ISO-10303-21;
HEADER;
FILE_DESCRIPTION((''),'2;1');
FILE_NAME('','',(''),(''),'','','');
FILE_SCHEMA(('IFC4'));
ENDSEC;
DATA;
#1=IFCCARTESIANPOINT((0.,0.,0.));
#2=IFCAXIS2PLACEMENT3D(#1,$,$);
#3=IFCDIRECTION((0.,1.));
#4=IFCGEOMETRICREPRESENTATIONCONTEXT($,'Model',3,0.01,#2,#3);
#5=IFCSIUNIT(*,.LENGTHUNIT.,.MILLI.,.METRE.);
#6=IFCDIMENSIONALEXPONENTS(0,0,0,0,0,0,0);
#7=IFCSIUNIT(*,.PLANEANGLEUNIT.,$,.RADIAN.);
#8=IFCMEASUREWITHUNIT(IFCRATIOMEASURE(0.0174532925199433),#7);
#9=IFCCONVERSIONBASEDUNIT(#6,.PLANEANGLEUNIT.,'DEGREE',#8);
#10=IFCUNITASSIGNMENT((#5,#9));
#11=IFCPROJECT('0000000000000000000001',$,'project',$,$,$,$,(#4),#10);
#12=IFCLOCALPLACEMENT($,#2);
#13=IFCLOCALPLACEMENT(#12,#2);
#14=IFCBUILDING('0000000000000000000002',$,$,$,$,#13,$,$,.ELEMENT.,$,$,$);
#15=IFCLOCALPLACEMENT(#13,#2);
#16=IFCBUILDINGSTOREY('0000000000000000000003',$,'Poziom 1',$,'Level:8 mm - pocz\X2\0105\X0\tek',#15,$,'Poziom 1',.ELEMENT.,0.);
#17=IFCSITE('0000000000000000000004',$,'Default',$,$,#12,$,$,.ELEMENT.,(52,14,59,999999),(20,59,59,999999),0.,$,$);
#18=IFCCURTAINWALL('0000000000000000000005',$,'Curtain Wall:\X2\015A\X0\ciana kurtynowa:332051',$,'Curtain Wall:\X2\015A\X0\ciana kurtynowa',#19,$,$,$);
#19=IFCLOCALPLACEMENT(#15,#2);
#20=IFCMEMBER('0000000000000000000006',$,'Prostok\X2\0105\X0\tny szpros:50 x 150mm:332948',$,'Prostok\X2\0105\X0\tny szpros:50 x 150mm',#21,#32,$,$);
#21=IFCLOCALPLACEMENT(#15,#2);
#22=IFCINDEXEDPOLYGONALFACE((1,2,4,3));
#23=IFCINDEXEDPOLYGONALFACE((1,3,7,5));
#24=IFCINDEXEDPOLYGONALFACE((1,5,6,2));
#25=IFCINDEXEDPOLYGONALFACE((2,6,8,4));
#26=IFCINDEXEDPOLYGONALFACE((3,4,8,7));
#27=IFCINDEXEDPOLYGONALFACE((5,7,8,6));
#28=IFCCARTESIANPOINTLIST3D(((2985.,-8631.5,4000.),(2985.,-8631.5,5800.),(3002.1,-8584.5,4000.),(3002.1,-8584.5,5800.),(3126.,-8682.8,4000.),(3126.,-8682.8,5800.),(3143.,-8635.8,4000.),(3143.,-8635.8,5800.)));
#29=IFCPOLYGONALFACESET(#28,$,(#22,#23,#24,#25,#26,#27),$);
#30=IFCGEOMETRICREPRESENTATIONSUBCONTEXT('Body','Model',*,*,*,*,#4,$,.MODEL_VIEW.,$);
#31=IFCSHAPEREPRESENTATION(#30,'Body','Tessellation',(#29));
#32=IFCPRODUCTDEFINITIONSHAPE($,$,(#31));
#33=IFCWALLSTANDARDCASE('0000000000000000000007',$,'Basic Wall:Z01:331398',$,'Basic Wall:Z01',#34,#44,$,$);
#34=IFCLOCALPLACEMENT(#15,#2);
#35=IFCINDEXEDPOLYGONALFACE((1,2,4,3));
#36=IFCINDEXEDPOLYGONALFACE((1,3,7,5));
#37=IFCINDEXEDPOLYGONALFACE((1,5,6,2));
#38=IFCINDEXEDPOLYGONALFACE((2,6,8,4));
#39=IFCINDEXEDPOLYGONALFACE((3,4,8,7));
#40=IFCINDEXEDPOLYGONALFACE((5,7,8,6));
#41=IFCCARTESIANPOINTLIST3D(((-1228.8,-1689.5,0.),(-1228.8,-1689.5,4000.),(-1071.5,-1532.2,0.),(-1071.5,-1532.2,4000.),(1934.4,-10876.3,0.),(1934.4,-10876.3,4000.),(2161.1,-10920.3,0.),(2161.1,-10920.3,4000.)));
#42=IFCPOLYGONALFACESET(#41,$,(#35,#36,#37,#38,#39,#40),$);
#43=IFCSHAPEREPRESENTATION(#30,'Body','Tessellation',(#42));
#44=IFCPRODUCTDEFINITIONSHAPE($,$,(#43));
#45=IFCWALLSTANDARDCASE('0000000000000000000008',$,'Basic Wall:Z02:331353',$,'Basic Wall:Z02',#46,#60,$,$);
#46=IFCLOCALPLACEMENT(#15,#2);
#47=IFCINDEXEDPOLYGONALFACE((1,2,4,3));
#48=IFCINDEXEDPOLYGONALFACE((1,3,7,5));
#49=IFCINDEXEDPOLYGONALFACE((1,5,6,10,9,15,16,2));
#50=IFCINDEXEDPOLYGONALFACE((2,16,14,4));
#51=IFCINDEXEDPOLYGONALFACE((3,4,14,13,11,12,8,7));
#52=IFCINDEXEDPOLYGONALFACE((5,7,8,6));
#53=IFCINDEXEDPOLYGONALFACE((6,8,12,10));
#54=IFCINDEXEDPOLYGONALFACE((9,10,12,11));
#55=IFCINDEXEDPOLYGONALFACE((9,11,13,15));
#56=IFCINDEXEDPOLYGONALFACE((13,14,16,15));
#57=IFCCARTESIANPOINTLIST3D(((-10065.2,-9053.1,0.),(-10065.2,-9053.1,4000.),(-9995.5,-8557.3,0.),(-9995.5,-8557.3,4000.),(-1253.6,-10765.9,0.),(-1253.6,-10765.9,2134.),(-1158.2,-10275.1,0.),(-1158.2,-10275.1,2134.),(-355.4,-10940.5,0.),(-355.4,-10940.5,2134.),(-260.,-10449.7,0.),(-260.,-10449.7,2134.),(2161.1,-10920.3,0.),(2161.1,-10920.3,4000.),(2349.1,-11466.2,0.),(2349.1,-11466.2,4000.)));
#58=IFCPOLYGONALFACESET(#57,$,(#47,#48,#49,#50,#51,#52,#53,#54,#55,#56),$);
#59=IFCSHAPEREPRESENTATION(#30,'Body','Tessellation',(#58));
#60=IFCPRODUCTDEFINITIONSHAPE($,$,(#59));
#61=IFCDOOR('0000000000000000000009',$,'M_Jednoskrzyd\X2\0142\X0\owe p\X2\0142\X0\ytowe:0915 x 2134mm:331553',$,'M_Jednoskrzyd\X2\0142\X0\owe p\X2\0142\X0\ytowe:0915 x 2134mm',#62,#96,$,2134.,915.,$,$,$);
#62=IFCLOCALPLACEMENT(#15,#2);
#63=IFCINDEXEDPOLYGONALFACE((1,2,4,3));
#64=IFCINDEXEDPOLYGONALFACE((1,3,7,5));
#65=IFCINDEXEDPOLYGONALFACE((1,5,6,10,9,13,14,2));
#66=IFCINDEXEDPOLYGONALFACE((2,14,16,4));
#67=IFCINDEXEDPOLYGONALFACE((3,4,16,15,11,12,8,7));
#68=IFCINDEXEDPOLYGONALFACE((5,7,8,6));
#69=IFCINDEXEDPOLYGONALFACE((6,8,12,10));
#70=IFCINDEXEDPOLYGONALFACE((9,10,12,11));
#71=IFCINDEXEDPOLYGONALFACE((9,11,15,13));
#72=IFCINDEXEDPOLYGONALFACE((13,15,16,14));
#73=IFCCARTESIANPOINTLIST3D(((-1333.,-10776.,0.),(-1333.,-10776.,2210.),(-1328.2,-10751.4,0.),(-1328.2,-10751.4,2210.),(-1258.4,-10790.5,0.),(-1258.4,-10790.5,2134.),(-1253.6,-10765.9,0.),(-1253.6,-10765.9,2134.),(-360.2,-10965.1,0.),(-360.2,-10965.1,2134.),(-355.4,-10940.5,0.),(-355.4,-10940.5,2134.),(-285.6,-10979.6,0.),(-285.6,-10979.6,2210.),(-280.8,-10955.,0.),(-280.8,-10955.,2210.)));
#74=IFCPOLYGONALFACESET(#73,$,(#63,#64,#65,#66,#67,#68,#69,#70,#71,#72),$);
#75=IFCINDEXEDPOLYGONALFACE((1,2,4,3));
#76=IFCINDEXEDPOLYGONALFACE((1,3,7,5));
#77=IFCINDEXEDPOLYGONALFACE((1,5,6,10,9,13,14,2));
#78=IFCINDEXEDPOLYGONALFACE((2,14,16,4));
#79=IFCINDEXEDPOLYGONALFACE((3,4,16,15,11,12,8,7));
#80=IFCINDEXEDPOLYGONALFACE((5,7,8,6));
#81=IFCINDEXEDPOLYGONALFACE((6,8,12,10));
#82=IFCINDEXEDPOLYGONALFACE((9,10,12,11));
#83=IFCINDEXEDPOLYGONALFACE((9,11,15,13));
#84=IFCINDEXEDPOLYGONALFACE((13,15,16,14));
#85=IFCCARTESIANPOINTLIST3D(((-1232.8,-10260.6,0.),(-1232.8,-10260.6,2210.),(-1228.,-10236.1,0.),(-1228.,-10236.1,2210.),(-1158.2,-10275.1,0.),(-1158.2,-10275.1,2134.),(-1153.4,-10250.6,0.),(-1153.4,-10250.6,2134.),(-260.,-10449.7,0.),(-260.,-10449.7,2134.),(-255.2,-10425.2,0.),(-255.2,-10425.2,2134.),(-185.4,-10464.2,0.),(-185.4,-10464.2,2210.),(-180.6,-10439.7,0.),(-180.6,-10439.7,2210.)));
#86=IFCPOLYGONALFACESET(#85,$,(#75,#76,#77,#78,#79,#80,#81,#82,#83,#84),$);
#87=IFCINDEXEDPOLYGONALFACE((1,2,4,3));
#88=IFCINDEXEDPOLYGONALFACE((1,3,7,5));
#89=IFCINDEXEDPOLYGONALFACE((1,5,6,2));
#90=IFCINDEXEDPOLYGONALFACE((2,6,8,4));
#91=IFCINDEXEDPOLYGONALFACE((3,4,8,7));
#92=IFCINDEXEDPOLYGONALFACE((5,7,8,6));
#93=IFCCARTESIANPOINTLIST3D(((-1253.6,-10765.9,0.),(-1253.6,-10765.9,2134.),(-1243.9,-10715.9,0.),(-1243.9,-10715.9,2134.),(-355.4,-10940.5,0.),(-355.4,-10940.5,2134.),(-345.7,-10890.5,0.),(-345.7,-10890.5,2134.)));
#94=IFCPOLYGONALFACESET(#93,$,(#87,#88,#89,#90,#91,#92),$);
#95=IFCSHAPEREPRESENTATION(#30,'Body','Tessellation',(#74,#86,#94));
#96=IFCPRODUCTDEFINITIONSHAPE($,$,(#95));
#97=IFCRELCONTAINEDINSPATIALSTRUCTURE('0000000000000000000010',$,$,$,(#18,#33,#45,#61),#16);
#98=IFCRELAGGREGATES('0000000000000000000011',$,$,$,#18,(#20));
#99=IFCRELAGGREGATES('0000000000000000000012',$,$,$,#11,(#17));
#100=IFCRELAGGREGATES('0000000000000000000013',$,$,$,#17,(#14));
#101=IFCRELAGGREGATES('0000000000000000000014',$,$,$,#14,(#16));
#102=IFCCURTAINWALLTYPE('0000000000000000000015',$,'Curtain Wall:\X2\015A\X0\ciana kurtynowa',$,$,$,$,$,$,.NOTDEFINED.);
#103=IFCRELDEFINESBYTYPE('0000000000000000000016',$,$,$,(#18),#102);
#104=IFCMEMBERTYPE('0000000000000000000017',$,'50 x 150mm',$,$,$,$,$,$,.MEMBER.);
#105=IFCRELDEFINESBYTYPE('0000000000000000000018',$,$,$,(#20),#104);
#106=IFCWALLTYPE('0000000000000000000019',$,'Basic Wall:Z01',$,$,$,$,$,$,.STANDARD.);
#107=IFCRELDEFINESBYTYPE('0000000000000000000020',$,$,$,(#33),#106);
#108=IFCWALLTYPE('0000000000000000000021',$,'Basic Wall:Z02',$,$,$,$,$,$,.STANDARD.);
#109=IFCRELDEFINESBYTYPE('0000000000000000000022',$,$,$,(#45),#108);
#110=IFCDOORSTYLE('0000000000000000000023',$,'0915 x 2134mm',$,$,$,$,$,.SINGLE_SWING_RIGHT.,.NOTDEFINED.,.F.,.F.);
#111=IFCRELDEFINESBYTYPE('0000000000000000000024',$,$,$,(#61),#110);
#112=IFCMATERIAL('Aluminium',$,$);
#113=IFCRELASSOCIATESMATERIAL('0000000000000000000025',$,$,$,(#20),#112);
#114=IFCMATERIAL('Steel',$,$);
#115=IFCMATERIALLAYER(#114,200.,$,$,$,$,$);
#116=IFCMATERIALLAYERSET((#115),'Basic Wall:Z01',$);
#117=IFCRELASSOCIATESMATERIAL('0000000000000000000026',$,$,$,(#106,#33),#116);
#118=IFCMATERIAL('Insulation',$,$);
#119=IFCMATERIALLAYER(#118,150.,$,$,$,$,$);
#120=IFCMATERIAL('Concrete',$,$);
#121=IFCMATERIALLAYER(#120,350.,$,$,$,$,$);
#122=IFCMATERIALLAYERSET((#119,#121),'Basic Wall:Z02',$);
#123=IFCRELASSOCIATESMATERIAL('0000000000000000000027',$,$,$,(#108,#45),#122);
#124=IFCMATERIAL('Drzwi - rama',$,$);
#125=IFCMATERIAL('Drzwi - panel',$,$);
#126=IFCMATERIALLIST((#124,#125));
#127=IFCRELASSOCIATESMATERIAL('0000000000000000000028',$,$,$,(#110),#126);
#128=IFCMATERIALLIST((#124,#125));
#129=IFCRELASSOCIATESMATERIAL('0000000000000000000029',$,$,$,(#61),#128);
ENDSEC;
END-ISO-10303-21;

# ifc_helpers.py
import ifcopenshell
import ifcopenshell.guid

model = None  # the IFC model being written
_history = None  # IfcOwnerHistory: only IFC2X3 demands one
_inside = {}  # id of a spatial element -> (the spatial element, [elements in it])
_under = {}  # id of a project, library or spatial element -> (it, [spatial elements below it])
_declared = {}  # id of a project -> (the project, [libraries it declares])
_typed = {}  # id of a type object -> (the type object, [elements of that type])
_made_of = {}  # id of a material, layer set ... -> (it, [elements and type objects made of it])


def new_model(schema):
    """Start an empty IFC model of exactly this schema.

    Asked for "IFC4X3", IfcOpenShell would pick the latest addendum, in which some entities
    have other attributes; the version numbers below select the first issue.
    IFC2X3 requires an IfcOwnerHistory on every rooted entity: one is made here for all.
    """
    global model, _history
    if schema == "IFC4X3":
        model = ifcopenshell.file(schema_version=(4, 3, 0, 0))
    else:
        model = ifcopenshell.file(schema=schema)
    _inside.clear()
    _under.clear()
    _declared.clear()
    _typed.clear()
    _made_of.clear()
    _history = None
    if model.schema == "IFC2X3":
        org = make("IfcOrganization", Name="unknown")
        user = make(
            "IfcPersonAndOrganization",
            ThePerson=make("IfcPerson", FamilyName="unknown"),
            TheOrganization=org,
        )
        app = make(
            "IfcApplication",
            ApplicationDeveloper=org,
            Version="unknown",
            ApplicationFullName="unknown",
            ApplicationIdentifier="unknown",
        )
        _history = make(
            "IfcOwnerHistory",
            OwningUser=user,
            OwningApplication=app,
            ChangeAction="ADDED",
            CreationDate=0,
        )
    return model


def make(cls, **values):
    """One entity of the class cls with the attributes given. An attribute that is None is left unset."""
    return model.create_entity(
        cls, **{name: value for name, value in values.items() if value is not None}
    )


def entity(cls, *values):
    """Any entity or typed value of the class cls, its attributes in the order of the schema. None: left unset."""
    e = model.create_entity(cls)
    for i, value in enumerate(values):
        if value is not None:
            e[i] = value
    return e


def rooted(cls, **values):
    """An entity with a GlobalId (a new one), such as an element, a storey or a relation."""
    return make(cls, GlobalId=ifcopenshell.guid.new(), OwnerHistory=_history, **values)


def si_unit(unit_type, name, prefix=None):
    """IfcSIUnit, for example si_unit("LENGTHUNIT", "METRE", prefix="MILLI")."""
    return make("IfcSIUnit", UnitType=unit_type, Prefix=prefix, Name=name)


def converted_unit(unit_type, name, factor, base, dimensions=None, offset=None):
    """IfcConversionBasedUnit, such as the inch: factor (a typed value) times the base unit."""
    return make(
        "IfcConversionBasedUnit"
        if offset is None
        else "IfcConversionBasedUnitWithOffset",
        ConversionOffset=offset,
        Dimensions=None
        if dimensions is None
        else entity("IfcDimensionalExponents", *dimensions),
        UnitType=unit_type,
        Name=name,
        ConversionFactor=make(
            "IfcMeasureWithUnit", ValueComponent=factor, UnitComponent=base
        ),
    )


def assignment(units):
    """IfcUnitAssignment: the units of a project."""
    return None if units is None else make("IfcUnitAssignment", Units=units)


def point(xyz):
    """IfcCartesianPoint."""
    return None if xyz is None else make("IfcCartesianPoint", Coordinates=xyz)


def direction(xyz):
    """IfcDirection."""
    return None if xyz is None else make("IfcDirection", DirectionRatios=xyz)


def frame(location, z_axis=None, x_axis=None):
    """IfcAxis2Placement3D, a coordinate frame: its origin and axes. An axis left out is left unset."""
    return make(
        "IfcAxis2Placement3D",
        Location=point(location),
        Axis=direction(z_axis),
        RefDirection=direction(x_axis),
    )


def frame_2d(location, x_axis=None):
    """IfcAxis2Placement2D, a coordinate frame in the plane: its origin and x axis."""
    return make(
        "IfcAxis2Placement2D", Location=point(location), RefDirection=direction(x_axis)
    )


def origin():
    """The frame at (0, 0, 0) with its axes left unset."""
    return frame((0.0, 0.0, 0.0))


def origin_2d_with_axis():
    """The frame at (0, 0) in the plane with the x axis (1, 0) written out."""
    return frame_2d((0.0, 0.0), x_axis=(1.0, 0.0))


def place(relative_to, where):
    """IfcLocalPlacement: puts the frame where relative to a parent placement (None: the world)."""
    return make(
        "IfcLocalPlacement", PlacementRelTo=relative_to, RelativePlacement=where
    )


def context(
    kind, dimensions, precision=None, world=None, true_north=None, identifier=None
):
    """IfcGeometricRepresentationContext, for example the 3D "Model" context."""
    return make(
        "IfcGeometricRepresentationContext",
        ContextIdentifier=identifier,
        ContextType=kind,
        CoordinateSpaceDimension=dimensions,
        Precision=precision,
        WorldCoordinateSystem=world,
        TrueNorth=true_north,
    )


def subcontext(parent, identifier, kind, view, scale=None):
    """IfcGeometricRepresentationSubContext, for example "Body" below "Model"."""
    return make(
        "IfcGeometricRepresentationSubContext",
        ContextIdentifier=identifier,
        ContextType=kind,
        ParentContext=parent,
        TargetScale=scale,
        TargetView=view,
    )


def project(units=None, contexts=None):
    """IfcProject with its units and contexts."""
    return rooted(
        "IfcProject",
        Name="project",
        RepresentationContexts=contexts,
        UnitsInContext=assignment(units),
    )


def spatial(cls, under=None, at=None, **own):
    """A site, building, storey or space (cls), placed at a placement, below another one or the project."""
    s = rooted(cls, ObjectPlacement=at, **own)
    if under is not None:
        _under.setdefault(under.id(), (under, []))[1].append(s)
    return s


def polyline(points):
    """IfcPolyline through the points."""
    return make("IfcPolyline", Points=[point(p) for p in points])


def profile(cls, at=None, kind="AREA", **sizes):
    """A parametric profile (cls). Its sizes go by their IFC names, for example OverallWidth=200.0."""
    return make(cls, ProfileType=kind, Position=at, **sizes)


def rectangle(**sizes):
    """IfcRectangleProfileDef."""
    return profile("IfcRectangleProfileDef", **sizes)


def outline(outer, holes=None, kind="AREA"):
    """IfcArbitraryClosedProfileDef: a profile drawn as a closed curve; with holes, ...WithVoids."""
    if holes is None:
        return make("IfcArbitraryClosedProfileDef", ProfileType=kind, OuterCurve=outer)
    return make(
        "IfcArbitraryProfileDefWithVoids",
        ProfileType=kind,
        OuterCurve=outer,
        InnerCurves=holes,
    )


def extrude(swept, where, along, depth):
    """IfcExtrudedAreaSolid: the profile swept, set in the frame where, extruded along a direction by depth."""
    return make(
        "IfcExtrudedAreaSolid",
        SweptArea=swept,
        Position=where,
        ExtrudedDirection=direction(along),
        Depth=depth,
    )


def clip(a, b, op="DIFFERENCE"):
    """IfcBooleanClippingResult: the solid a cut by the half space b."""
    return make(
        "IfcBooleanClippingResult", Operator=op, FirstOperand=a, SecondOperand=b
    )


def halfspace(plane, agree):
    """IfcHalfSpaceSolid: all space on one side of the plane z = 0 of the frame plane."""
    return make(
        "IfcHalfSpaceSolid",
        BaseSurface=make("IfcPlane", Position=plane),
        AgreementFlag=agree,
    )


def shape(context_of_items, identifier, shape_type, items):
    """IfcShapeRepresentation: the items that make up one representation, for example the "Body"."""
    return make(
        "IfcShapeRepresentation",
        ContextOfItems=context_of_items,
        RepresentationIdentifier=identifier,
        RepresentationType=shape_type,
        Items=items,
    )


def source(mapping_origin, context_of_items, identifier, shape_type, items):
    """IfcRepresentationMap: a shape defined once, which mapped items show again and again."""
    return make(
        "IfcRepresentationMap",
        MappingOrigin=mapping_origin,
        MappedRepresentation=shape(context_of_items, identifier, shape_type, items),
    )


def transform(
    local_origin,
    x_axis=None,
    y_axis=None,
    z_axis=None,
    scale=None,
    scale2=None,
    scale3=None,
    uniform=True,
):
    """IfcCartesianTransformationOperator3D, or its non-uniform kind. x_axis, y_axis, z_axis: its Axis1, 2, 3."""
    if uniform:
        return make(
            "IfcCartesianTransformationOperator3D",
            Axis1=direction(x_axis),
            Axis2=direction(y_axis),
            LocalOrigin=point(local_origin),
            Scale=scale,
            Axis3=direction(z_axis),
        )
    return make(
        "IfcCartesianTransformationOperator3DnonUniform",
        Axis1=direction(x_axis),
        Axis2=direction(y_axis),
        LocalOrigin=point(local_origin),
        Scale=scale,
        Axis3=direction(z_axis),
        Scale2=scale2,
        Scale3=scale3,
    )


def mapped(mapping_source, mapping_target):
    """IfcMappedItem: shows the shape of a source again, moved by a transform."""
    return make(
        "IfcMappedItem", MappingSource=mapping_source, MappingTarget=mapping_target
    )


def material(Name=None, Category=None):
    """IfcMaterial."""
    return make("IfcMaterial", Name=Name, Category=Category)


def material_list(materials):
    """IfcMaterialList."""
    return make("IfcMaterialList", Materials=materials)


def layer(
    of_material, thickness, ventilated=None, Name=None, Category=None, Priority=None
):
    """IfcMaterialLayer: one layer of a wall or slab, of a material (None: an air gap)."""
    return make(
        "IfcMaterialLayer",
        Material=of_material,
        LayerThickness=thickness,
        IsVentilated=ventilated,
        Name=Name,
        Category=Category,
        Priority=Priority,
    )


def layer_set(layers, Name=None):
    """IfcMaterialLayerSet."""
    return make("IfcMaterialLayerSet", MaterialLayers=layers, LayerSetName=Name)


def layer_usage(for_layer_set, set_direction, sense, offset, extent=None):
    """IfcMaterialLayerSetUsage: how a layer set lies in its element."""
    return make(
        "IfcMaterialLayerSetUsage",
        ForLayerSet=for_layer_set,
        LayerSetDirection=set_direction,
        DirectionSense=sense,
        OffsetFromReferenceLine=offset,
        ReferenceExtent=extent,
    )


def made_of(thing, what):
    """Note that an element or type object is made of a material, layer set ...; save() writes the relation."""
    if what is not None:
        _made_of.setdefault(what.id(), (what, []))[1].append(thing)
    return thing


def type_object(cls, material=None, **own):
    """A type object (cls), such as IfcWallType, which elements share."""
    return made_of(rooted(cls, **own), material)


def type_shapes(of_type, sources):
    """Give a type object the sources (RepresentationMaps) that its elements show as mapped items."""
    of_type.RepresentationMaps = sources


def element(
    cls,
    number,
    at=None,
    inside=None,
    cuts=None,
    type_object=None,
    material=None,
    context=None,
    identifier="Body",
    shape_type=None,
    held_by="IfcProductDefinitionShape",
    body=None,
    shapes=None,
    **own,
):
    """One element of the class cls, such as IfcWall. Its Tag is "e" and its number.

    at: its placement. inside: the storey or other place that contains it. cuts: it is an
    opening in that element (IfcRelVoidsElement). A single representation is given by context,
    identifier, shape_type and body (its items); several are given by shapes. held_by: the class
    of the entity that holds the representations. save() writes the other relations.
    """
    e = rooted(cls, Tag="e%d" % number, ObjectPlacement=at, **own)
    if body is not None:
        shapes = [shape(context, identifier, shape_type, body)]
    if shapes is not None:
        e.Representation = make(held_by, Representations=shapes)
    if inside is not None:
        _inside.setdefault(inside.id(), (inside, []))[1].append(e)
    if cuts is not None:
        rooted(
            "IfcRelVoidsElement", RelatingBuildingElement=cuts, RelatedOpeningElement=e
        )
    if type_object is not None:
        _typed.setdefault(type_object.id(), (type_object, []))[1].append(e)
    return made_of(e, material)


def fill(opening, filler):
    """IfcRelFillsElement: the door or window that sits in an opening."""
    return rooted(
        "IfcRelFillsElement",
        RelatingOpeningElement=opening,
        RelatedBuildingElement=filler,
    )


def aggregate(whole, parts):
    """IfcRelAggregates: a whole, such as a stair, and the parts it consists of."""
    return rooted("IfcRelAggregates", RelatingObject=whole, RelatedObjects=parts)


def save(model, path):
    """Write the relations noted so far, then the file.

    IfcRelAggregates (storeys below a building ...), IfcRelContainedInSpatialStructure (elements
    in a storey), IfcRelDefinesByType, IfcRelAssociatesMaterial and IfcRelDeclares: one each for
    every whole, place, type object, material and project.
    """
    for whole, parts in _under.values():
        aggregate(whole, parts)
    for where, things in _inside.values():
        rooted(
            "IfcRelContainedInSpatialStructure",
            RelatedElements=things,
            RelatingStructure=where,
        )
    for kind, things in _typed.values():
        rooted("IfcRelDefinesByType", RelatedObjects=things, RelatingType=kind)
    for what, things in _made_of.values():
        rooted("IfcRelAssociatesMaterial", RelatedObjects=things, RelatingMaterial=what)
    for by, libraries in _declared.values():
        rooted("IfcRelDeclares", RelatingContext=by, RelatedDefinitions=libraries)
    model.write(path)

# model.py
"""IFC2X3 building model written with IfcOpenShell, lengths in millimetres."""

from ifc_helpers import new_model, entity, si_unit, converted_unit, direction, frame, frame_2d, origin, origin_2d_with_axis, place, context, subcontext, project, spatial, polyline, rectangle, outline, extrude, clip, halfspace, source, transform, mapped, material, material_list, layer, layer_set, layer_usage, type_object, type_shapes, element, fill, aggregate, save


model = new_model("IFC2X3")

# Units and contexts
model_context = context("Model", 3, precision=0.01, world=origin(), true_north=direction((0.0, 1.0)))
body_context = subcontext(model_context, "Body", "Model", "MODEL_VIEW")
ifc_project = project(units=[si_unit("LENGTHUNIT", "METRE", prefix="MILLI"), converted_unit("PLANEANGLEUNIT", "DEGREE", entity("IfcRatioMeasure", 0.0174532925199433), si_unit("PLANEANGLEUNIT", "RADIAN"), dimensions=[0, 0, 0, 0, 0, 0, 0])], contexts=[model_context])

# Site, building, storey
site_placement = place(None, origin())
site = spatial("IfcSite", under=ifc_project, at=site_placement, Name="Default", CompositionType="ELEMENT", RefLatitude=(52, 14, 59, 999999), RefLongitude=(20, 59, 59, 999999), RefElevation=0.0)
building_placement = place(site_placement, origin())
building = spatial("IfcBuilding", under=site, at=building_placement, CompositionType="ELEMENT")
storey_placement = place(building_placement, origin())
storey = spatial("IfcBuildingStorey", under=building, at=storey_placement, Name="Poziom 1", ObjectType="Level:8 mm - początek", LongName="Poziom 1", CompositionType="ELEMENT", Elevation=0.0)

# Curtain wall, member
curtain_wall_type = type_object("IfcCurtainWallType", Name="Curtain Wall:Ściana kurtynowa", PredefinedType="NOTDEFINED")
curtain_wall_placement = place(storey_placement, origin())
curtain_wall = element("IfcCurtainWall", 1, at=curtain_wall_placement, inside=storey, type_object=curtain_wall_type, Name="Curtain Wall:Ściana kurtynowa:332051", ObjectType="Curtain Wall:Ściana kurtynowa")
ifc_material_1 = material(Name="Aluminium")
member_type_1 = type_object("IfcMemberType", Name="50 x 150mm", PredefinedType="MEMBER")
shared_shape_1 = source(origin(), body_context, "Body", "SweptSolid", [
    extrude(rectangle(XDim=150.0, YDim=50.0, at=origin_2d_with_axis()), frame((0.0, 0.0, -1800.0), z_axis=(0.0, 0.0, 1.0), x_axis=(0.0, -1.0, 0.0)), (0.0, 0.0, 1.0), 1800.0),
])
type_shapes(member_type_1, [shared_shape_1])
member_1_placement = place(storey_placement, frame((3064.0, -8633.7, 4000.0), z_axis=(0.0, 0.0, -1.0), x_axis=(0.341586, 0.939851, 0.0)))
member_1 = element("IfcMember", 2, at=member_1_placement, type_object=member_type_1, material=ifc_material_1, Name="Prostokątny szpros:50 x 150mm:332948", ObjectType="Prostokątny szpros:50 x 150mm", context=body_context, shape_type="MappedRepresentation", body=[
    mapped(shared_shape_1, transform((0.0, 0.0, 0.0), scale=1.0)),
])
aggregate(curtain_wall, [member_1])

# Wall
ifc_material_2 = material(Name="Steel")
ifc_layer_1 = layer(ifc_material_2, 200.0)
ifc_layer_set_1 = layer_set([ifc_layer_1], Name="Basic Wall:Z01")
ifc_layer_usage_1 = layer_usage(ifc_layer_set_1, "AXIS2", "NEGATIVE", 100.0)
wall_type_1 = type_object("IfcWallType", Name="Basic Wall:Z01", PredefinedType="STANDARD", material=ifc_layer_set_1)
wall_1_placement = place(storey_placement, frame((2066.5, -10952.9, 0.0), z_axis=(0.0, 0.0, 1.0), x_axis=(-0.325568, 0.945519, 0.0)))
element("IfcWallStandardCase", 3, at=wall_1_placement, inside=storey, type_object=wall_type_1, material=ifc_layer_usage_1, Name="Basic Wall:Z01:331398", ObjectType="Basic Wall:Z01", context=body_context, shape_type="Clipping", body=[
    clip(extrude(outline(polyline([(9929.1, -100.0), (9831.5, 100.0), (115.5, 100.0), (0.0, -100.0), (9706.6, -100.0), (9929.1, -100.0)])), origin(), (0.0, 0.0, 1.0), 4000.0), halfspace(origin(), True)),
])

# Wall, opening, door
ifc_material_3 = material(Name="Insulation")
ifc_layer_2 = layer(ifc_material_3, 150.0)
ifc_material_4 = material(Name="Concrete")
ifc_layer_3 = layer(ifc_material_4, 350.0)
ifc_layer_set_2 = layer_set([ifc_layer_2, ifc_layer_3], Name="Basic Wall:Z02")
ifc_layer_usage_2 = layer_usage(ifc_layer_set_2, "AXIS2", "NEGATIVE", 250.0)
wall_type_2 = type_object("IfcWallType", Name="Basic Wall:Z02", PredefinedType="STANDARD", material=ifc_layer_set_2)
wall_2_placement = place(storey_placement, frame((-10043.2, -8802.7, 0.0), z_axis=(0.0, 0.0, 1.0), x_axis=(0.981627, -0.190809, 0.0)))
wall_2 = element("IfcWallStandardCase", 4, at=wall_2_placement, inside=storey, type_object=wall_type_2, material=ifc_layer_usage_2, Name="Basic Wall:Z02:331353", ObjectType="Basic Wall:Z02", context=body_context, shape_type="Clipping", body=[
    clip(extrude(outline(polyline([(26.2, -250.0), (12672.8, -250.0), (12384.1, 250.0), (12153.2, 250.0), (0.0, 250.0), (26.2, -250.0)])), origin(), (0.0, 0.0, 1.0), 4000.0), halfspace(origin(), True)),
])
opening_placement = place(wall_2_placement, frame((9917.7, 250.0, 0.0)))
opening = element("IfcOpeningElement", 5, at=opening_placement, cuts=wall_2, ObjectType="Opening", context=body_context, shape_type="SweptSolid", body=[
    extrude(rectangle(XDim=915.0, YDim=2134.0, at=frame_2d((1067.0, 457.5), x_axis=(0.0, 1.0))), frame((0.0, 0.0, 0.0), z_axis=(0.0, -1.0, 0.0), x_axis=(0.0, 0.0, 1.0)), (0.0, 0.0, 1.0), 500.0),
])
ifc_material_5 = material(Name="Drzwi - rama")
ifc_material_6 = material(Name="Drzwi - panel")
ifc_material_list_1 = material_list([ifc_material_5, ifc_material_6])
ifc_material_list_2 = material_list([ifc_material_5, ifc_material_6])
door_style = type_object("IfcDoorStyle", Name="0915 x 2134mm", ConstructionType="NOTDEFINED", OperationType="SINGLE_SWING_RIGHT", ParameterTakesPrecedence=False, Sizeable=False, material=ifc_material_list_2)
shared_shape_2 = source(origin(), body_context, "Body", "SweptSolid", [
    extrude(outline(polyline([(-533.5, -1124.0), (533.5, -1124.0), (533.5, 1086.0), (457.5, 1086.0), (457.5, -1048.0), (-457.5, -1048.0), (-457.5, 1086.0), (-533.5, 1086.0), (-533.5, -1124.0)])), frame((457.5, 500.0, 1086.0), z_axis=(0.0, 1.0, 0.0), x_axis=(1.0, 0.0, 0.0)), (0.0, 0.0, 1.0), 25.0),
    extrude(outline(polyline([(-1124.0, -533.5), (1086.0, -533.5), (1086.0, -457.5), (-1048.0, -457.5), (-1048.0, 457.5), (1086.0, 457.5), (1086.0, 533.5), (-1124.0, 533.5), (-1124.0, -533.5)])), frame((457.5, -25.0, 1086.0), z_axis=(0.0, 1.0, 0.0), x_axis=(0.0, 0.0, -1.0)), (0.0, 0.0, 1.0), 25.0),
    extrude(rectangle(XDim=51.0, YDim=915.0, at=frame_2d((0.0, 0.0), x_axis=(1.0, 0.0))), frame((457.5, 474.5, 0.0), z_axis=(0.0, 0.0, 1.0), x_axis=(0.0, 1.0, 0.0)), (0.0, 0.0, 1.0), 2134.0),
])
type_shapes(door_style, [shared_shape_2])
door_placement = place(opening_placement, frame((0.0, 0.0, 0.0), z_axis=(0.0, 0.0, 1.0), x_axis=(-1.0, 0.0, 0.0)))
door = element("IfcDoor", 6, at=door_placement, inside=storey, type_object=door_style, material=ifc_material_list_1, Name="M_Jednoskrzydłowe płytowe:0915 x 2134mm:331553", ObjectType="M_Jednoskrzydłowe płytowe:0915 x 2134mm", OverallHeight=2134.0, OverallWidth=915.0, context=body_context, shape_type="MappedRepresentation", body=[
    mapped(shared_shape_2, transform((0.0, 0.0, 0.0), scale=1.0)),
])
fill(opening, door)

save(model, "model.ifc")
